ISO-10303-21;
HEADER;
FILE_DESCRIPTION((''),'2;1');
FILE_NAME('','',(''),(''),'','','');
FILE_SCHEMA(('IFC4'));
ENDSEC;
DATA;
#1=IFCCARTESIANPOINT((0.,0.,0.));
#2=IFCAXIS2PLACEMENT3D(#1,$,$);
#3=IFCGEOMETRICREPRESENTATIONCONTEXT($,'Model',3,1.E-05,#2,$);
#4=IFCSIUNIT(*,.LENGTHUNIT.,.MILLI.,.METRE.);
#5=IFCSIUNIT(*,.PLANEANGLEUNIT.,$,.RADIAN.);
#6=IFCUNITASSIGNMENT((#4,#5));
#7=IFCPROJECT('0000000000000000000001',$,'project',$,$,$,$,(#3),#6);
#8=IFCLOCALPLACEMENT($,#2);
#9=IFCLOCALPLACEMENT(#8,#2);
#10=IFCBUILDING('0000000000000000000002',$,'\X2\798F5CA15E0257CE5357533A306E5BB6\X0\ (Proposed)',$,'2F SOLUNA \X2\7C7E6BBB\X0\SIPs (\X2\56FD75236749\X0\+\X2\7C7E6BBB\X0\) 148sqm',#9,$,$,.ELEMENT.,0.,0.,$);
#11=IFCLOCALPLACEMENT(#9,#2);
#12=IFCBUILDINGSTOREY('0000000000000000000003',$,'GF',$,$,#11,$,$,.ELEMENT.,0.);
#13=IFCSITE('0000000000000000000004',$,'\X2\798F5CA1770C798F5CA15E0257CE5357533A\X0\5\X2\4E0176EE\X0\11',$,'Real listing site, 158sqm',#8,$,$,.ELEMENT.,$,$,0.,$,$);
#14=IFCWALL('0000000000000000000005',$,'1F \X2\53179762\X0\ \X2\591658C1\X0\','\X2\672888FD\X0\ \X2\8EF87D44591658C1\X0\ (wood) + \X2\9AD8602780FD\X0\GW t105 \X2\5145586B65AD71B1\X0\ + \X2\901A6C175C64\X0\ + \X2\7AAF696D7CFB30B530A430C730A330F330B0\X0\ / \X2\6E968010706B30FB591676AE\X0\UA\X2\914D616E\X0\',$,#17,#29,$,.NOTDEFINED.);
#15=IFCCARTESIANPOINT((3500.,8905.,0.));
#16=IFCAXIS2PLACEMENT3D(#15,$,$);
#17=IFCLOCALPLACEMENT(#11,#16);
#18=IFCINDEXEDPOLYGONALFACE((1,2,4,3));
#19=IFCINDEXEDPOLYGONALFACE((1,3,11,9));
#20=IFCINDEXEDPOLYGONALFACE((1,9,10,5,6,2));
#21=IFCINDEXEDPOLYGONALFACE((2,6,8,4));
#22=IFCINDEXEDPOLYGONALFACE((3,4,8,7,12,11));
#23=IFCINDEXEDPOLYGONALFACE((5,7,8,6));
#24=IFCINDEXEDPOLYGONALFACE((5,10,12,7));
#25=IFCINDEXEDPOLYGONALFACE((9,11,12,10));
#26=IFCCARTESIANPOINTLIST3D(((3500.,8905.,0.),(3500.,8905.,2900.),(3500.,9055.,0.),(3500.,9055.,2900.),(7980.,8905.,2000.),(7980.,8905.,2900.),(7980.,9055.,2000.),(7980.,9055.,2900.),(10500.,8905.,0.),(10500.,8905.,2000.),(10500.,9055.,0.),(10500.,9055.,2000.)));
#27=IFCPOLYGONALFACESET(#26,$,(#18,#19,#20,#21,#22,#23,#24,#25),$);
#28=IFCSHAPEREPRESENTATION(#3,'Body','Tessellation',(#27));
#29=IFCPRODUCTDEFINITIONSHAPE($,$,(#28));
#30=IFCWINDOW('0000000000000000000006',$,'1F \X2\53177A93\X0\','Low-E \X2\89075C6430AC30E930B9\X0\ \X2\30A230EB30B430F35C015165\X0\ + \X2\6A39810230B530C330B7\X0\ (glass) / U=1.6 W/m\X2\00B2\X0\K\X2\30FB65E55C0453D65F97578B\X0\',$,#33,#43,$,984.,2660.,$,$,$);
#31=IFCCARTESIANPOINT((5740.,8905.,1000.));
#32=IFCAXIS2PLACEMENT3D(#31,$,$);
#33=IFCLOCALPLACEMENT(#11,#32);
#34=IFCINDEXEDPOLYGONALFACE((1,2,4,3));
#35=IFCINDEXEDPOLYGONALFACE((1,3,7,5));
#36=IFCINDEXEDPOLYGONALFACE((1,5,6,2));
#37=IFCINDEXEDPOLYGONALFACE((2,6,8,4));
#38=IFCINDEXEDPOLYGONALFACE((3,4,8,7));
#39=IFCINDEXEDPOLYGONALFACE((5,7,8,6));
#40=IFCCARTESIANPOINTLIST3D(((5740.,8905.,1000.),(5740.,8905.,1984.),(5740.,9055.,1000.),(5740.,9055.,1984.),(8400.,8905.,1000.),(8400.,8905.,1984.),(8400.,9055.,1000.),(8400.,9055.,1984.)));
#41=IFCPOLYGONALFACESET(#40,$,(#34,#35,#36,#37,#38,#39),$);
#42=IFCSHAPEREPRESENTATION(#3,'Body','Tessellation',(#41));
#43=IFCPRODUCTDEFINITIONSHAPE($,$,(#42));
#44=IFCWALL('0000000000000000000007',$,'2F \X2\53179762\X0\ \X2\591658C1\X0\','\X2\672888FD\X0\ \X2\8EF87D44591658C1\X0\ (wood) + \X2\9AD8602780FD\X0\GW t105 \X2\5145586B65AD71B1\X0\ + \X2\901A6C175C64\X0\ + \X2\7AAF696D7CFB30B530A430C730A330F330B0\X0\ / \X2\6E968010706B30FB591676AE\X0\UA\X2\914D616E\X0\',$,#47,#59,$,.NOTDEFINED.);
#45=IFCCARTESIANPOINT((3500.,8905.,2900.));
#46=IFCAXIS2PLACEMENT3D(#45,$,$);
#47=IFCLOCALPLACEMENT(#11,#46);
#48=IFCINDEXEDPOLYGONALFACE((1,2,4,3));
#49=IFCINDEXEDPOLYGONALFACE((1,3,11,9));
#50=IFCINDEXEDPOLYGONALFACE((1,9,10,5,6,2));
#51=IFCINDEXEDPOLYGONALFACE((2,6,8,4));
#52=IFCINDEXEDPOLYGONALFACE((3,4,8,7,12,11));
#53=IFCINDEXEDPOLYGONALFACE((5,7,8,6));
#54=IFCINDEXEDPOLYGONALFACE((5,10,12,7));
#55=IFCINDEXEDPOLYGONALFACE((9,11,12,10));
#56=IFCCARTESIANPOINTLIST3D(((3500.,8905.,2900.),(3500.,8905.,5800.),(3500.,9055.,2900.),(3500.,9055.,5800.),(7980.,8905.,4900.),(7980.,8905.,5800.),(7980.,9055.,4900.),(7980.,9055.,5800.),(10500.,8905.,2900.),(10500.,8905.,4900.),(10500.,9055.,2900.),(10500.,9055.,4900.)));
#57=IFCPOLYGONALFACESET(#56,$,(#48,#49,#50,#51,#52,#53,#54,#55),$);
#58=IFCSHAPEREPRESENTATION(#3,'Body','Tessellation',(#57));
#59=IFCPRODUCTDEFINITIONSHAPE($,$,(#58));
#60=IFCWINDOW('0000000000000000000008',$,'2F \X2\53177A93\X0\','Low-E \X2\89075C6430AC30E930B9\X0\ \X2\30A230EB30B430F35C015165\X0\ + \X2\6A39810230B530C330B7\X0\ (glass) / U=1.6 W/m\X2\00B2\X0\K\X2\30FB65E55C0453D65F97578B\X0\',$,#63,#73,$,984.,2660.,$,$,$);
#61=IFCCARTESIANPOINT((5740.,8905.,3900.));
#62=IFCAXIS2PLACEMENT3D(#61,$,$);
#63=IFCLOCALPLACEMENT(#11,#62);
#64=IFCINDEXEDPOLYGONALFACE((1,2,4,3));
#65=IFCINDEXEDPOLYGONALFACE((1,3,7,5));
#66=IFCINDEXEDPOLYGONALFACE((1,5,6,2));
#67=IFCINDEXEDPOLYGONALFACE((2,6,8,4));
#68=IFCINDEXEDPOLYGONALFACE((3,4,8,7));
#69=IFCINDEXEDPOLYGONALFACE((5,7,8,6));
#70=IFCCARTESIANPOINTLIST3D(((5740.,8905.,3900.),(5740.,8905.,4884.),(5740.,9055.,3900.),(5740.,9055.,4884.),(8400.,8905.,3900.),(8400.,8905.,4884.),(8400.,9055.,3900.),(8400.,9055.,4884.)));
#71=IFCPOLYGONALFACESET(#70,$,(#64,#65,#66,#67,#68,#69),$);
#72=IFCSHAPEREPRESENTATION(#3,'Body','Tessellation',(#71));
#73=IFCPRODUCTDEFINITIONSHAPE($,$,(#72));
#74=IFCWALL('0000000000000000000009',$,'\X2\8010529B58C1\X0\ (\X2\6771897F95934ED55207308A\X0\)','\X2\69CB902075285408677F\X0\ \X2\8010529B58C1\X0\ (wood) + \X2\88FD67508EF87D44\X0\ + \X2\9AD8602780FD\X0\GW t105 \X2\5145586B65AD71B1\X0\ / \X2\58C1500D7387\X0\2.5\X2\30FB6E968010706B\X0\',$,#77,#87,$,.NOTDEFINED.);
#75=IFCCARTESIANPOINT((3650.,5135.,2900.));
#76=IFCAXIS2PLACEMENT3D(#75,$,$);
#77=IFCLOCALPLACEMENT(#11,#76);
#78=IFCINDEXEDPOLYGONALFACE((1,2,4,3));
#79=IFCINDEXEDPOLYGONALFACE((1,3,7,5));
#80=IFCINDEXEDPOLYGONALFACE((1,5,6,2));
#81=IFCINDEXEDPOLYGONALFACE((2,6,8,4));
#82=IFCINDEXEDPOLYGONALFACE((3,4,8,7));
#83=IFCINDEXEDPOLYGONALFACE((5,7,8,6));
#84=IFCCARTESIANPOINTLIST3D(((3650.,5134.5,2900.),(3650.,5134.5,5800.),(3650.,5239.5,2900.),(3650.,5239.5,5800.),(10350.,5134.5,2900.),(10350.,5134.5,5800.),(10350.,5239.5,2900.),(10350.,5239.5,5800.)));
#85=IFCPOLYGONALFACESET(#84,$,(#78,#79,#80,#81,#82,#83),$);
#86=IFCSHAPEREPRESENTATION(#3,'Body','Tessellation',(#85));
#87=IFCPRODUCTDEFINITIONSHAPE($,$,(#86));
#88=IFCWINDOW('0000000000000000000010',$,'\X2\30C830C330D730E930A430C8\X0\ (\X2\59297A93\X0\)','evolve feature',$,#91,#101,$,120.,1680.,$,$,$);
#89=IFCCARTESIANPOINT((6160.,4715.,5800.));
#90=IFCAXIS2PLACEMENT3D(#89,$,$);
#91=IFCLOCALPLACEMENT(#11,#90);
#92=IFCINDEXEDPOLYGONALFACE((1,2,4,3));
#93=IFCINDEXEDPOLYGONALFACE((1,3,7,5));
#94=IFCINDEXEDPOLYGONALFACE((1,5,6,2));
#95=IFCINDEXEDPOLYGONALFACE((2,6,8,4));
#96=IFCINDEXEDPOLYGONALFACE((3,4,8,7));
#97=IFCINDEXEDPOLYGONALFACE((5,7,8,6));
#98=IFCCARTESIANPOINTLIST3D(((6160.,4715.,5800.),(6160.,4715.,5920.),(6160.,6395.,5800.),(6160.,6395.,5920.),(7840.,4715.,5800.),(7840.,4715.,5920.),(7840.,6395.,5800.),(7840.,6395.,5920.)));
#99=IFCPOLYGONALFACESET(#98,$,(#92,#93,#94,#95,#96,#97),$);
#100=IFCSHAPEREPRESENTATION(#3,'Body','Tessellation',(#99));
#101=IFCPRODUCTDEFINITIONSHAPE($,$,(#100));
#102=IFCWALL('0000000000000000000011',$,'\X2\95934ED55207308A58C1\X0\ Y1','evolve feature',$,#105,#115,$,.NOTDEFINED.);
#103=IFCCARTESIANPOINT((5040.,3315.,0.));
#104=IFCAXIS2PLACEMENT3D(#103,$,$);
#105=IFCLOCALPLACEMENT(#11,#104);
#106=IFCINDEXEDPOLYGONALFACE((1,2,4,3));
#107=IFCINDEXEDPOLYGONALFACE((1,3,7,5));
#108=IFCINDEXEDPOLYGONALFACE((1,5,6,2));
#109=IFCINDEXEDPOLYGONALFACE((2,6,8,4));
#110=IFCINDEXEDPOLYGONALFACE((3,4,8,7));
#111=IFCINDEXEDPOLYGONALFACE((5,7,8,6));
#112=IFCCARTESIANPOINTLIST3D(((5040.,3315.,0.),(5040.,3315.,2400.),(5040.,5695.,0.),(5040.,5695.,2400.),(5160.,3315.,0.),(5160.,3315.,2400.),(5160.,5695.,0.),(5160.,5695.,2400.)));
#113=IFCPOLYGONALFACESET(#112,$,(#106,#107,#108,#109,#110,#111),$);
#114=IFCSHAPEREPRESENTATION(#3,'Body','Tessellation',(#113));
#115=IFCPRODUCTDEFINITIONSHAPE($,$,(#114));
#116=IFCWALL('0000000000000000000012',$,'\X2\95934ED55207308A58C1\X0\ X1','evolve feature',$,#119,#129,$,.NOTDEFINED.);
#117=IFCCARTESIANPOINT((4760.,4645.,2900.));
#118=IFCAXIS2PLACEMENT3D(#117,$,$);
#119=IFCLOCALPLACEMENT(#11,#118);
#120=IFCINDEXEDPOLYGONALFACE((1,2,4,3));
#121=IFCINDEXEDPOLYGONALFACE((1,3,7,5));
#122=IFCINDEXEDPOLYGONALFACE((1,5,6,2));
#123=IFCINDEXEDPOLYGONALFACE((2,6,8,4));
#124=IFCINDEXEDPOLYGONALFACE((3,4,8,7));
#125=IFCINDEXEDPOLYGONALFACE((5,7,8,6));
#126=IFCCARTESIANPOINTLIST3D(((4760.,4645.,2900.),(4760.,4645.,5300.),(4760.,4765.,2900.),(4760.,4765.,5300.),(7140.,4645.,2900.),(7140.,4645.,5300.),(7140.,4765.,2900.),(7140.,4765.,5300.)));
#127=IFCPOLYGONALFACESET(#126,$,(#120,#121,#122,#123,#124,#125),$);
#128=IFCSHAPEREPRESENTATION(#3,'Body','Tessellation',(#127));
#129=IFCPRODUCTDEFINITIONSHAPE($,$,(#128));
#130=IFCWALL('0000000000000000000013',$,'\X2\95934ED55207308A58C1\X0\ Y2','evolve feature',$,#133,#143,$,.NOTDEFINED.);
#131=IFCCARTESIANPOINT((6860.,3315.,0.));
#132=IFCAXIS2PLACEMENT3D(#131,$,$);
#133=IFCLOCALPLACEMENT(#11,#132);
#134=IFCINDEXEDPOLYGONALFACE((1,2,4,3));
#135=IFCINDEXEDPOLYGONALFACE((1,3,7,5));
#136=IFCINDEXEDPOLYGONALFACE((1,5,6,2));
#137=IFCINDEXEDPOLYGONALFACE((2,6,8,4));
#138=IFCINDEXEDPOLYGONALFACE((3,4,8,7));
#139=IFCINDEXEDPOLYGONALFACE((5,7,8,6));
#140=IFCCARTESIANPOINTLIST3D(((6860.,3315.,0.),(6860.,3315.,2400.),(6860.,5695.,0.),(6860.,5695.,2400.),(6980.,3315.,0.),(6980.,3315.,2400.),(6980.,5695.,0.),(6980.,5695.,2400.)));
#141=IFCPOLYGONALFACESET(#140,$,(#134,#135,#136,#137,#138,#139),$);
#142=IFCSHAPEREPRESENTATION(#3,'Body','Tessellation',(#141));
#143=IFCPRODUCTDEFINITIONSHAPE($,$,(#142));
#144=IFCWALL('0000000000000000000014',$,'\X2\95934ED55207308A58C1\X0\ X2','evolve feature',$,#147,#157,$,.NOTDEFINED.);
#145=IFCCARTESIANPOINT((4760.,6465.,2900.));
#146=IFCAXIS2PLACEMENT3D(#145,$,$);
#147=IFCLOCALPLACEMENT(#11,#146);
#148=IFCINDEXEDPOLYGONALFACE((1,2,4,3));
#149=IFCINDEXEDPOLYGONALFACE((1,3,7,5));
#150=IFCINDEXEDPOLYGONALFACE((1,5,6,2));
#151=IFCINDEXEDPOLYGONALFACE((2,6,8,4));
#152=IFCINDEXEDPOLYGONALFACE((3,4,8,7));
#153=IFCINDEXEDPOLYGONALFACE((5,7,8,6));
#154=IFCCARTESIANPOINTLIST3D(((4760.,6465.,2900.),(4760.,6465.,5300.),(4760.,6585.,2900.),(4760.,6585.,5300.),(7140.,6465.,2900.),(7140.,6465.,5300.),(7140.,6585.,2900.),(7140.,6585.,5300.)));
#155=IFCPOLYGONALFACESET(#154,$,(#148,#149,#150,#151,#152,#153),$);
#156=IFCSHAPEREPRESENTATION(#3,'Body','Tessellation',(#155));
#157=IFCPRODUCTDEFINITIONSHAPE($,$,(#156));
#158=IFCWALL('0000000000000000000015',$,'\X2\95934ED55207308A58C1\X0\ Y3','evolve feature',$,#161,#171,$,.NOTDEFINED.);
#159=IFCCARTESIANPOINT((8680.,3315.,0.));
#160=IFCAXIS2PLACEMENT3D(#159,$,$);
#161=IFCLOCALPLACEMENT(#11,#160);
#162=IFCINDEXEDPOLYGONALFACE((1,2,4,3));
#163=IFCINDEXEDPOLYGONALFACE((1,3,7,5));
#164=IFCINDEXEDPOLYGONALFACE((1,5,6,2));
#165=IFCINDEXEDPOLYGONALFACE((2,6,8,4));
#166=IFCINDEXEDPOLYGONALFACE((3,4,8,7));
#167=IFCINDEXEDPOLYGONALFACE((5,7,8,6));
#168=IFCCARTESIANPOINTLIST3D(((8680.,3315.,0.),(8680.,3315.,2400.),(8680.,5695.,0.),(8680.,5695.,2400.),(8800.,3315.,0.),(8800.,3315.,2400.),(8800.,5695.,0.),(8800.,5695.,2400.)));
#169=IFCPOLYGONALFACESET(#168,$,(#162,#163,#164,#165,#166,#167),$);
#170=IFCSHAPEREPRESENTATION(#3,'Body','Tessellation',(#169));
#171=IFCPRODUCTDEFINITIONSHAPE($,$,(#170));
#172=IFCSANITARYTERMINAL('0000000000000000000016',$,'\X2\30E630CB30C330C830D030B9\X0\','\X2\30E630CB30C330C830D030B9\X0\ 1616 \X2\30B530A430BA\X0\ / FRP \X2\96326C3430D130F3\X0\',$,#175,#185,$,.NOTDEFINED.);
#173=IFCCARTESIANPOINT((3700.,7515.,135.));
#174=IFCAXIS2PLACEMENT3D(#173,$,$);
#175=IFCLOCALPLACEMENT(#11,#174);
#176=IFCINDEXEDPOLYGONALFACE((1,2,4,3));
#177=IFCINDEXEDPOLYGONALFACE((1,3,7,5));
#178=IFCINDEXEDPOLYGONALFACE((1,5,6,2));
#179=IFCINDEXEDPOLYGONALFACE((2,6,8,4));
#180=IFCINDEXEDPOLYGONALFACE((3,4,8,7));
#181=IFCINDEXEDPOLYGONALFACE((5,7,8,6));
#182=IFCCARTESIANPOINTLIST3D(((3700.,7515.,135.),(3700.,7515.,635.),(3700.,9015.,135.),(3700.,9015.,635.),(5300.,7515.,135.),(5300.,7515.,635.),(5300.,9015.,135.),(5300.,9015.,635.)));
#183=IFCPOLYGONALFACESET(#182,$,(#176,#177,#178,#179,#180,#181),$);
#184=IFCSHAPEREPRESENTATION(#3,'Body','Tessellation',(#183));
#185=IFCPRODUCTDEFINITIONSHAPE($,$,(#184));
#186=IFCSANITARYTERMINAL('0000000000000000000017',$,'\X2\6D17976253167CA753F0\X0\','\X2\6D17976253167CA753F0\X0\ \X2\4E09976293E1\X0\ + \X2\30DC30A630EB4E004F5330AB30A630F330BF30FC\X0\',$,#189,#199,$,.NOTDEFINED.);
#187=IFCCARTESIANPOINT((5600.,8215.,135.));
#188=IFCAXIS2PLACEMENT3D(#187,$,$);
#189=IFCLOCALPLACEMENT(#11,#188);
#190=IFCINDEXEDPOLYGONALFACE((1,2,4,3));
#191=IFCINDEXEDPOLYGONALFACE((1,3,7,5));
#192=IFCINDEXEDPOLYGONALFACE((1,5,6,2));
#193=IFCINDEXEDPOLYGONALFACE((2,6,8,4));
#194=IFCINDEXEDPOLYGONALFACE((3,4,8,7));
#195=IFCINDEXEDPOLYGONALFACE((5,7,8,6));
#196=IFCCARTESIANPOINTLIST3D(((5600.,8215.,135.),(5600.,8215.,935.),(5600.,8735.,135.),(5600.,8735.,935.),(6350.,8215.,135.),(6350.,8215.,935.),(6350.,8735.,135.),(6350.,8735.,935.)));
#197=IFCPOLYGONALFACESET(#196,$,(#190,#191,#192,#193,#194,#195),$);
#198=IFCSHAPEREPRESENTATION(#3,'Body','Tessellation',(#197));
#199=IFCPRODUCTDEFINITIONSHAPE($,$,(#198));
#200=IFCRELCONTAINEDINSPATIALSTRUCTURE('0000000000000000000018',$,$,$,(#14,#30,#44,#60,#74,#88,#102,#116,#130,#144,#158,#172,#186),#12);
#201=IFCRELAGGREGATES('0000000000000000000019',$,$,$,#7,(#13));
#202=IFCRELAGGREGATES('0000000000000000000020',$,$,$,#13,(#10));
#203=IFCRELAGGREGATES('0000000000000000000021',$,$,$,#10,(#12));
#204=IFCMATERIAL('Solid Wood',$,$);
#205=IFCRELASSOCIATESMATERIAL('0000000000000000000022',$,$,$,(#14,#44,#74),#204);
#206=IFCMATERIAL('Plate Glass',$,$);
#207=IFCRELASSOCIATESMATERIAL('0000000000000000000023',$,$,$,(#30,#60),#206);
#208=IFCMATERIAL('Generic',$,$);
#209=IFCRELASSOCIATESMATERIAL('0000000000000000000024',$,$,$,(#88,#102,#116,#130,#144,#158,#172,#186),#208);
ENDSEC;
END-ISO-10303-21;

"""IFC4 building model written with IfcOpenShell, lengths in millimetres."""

from ifc_helpers import new_model, si_unit, frame, frame_2d, origin, place, context, project, spatial, rectangle, extrude, material, element, fill, save


model = new_model("IFC4")

# Units and contexts
model_context = context("Model", 3, precision=1e-05, world=origin())
ifc_project = project(units=[si_unit("LENGTHUNIT", "METRE", prefix="MILLI"), si_unit("PLANEANGLEUNIT", "RADIAN")], contexts=[model_context])

# Site, building, storey
site_placement = place(None, origin())
site = spatial("IfcSite", under=ifc_project, at=site_placement, Name="福岡県福岡市城南区5丁目11", ObjectType="Real listing site, 158sqm", CompositionType="ELEMENT", RefElevation=0.0)
building_placement = place(site_placement, origin())
building = spatial("IfcBuilding", under=site, at=building_placement, Name="福岡市城南区の家 (Proposed)", ObjectType="2F SOLUNA 籾殻SIPs (国産杉+籾殻) 148sqm", CompositionType="ELEMENT", ElevationOfRefHeight=0.0, ElevationOfTerrain=0.0)
storey_placement = place(building_placement, origin())
storey = spatial("IfcBuildingStorey", under=building, at=storey_placement, Name="GF", CompositionType="ELEMENT", Elevation=0.0)

# Wall, opening, window
ifc_material_1 = material(Name="Solid Wood")
wall_1_placement = place(storey_placement, frame((3500.0, 8905.0, 0.0)))
wall_1 = element("IfcWall", 1, at=wall_1_placement, inside=storey, material=ifc_material_1, Name="1F 北面 外壁", Description="木製 軸組外壁 (wood) + 高性能GW t105 充填断熱 + 通気層 + 窯業系サイディング / 準耐火・外皮UA配慮", PredefinedType="NOTDEFINED", context=model_context, shape_type="SweptSolid", body=[
    extrude(rectangle(XDim=7000.0, YDim=150.0, at=frame_2d((3500.0, 75.0))), frame((3500.0, 8905.0, 0.0)), (0.0, 0.0, 1.0), 2900.0),
])
opening_1_placement = place(storey_placement, frame((5740.0, 8905.0, 1000.0)))
opening_1 = element("IfcOpeningElement", 2, at=opening_1_placement, cuts=wall_1, PredefinedType="NOTDEFINED", context=model_context, shape_type="SweptSolid", body=[
    extrude(rectangle(XDim=2660.0, YDim=150.0, at=frame_2d((1330.0, 75.0))), frame((5740.0, 8905.0, 1000.0)), (0.0, 0.0, 1.0), 984.0),
])
ifc_material_2 = material(Name="Plate Glass")
window_1_placement = place(storey_placement, frame((5740.0, 8905.0, 1000.0)))
window_1 = element("IfcWindow", 3, at=window_1_placement, inside=storey, material=ifc_material_2, Name="1F 北窓", Description="Low-E 複層ガラス アルゴン封入 + 樹脂サッシ (glass) / U=1.6 W/m²K・日射取得型", OverallHeight=984.0, OverallWidth=2660.0, context=model_context, shape_type="SweptSolid", body=[
    extrude(rectangle(XDim=2660.0, YDim=150.0, at=frame_2d((1330.0, 75.0))), frame((5740.0, 8905.0, 1000.0)), (0.0, 0.0, 1.0), 984.0),
])
fill(opening_1, window_1)

# Wall, opening, window
wall_2_placement = place(storey_placement, frame((3500.0, 8905.0, 2900.0)))
wall_2 = element("IfcWall", 4, at=wall_2_placement, inside=storey, material=ifc_material_1, Name="2F 北面 外壁", Description="木製 軸組外壁 (wood) + 高性能GW t105 充填断熱 + 通気層 + 窯業系サイディング / 準耐火・外皮UA配慮", PredefinedType="NOTDEFINED", context=model_context, shape_type="SweptSolid", body=[
    extrude(rectangle(XDim=7000.0, YDim=150.0, at=frame_2d((3500.0, 75.0))), frame((3500.0, 8905.0, 2900.0)), (0.0, 0.0, 1.0), 2900.0),
])
opening_2_placement = place(storey_placement, frame((5740.0, 8905.0, 3900.0)))
opening_2 = element("IfcOpeningElement", 5, at=opening_2_placement, cuts=wall_2, PredefinedType="NOTDEFINED", context=model_context, shape_type="SweptSolid", body=[
    extrude(rectangle(XDim=2660.0, YDim=150.0, at=frame_2d((1330.0, 75.0))), frame((5740.0, 8905.0, 3900.0)), (0.0, 0.0, 1.0), 984.0),
])
window_2_placement = place(storey_placement, frame((5740.0, 8905.0, 3900.0)))
window_2 = element("IfcWindow", 6, at=window_2_placement, inside=storey, material=ifc_material_2, Name="2F 北窓", Description="Low-E 複層ガラス アルゴン封入 + 樹脂サッシ (glass) / U=1.6 W/m²K・日射取得型", OverallHeight=984.0, OverallWidth=2660.0, context=model_context, shape_type="SweptSolid", body=[
    extrude(rectangle(XDim=2660.0, YDim=150.0, at=frame_2d((1330.0, 75.0))), frame((5740.0, 8905.0, 3900.0)), (0.0, 0.0, 1.0), 984.0),
])
fill(opening_2, window_2)

# Wall
wall_3_placement = place(storey_placement, frame((3650.0, 5135.0, 2900.0)))
element("IfcWall", 7, at=wall_3_placement, inside=storey, material=ifc_material_1, Name="耐力壁 (東西間仕切り)", Description="構造用合板 耐力壁 (wood) + 製材軸組 + 高性能GW t105 充填断熱 / 壁倍率2.5・準耐火", PredefinedType="NOTDEFINED", context=model_context, shape_type="SweptSolid", body=[
    extrude(rectangle(XDim=6700.0, YDim=105.0, at=frame_2d((3350.0, 52.0))), frame((3650.0, 5135.0, 2900.0)), (0.0, 0.0, 1.0), 2900.0),
])

# Window
ifc_material_3 = material(Name="Generic")
window_3_placement = place(storey_placement, frame((6160.0, 4715.0, 5800.0)))
element("IfcWindow", 8, at=window_3_placement, inside=storey, material=ifc_material_3, Name="トップライト (天窓)", Description="evolve feature", OverallHeight=120.0, OverallWidth=1680.0, context=model_context, shape_type="SweptSolid", body=[
    extrude(rectangle(XDim=1680.0, YDim=1680.0, at=frame_2d((840.0, 840.0))), frame((6160.0, 4715.0, 5800.0)), (0.0, 0.0, 1.0), 120.0),
])

# Walls
wall_4_placement = place(storey_placement, frame((5040.0, 3315.0, 0.0)))
element("IfcWall", 9, at=wall_4_placement, inside=storey, material=ifc_material_3, Name="間仕切り壁 Y1", Description="evolve feature", PredefinedType="NOTDEFINED", context=model_context, shape_type="SweptSolid", body=[
    extrude(rectangle(XDim=120.0, YDim=2380.0, at=frame_2d((60.0, 1190.0))), frame((5040.0, 3315.0, 0.0)), (0.0, 0.0, 1.0), 2400.0),
])
wall_5_placement = place(storey_placement, frame((4760.0, 4645.0, 2900.0)))
element("IfcWall", 10, at=wall_5_placement, inside=storey, material=ifc_material_3, Name="間仕切り壁 X1", Description="evolve feature", PredefinedType="NOTDEFINED", context=model_context, shape_type="SweptSolid", body=[
    extrude(rectangle(XDim=2380.0, YDim=120.0, at=frame_2d((1190.0, 60.0))), frame((4760.0, 4645.0, 2900.0)), (0.0, 0.0, 1.0), 2400.0),
])
wall_6_placement = place(storey_placement, frame((6860.0, 3315.0, 0.0)))
element("IfcWall", 11, at=wall_6_placement, inside=storey, material=ifc_material_3, Name="間仕切り壁 Y2", Description="evolve feature", PredefinedType="NOTDEFINED", context=model_context, shape_type="SweptSolid", body=[
    extrude(rectangle(XDim=120.0, YDim=2380.0, at=frame_2d((60.0, 1190.0))), frame((6860.0, 3315.0, 0.0)), (0.0, 0.0, 1.0), 2400.0),
])
wall_7_placement = place(storey_placement, frame((4760.0, 6465.0, 2900.0)))
element("IfcWall", 12, at=wall_7_placement, inside=storey, material=ifc_material_3, Name="間仕切り壁 X2", Description="evolve feature", PredefinedType="NOTDEFINED", context=model_context, shape_type="SweptSolid", body=[
    extrude(rectangle(XDim=2380.0, YDim=120.0, at=frame_2d((1190.0, 60.0))), frame((4760.0, 6465.0, 2900.0)), (0.0, 0.0, 1.0), 2400.0),
])
wall_8_placement = place(storey_placement, frame((8680.0, 3315.0, 0.0)))
element("IfcWall", 13, at=wall_8_placement, inside=storey, material=ifc_material_3, Name="間仕切り壁 Y3", Description="evolve feature", PredefinedType="NOTDEFINED", context=model_context, shape_type="SweptSolid", body=[
    extrude(rectangle(XDim=120.0, YDim=2380.0, at=frame_2d((60.0, 1190.0))), frame((8680.0, 3315.0, 0.0)), (0.0, 0.0, 1.0), 2400.0),
])

# Sanitary terminals
sanitary_terminal_1_placement = place(storey_placement, frame((3700.0, 7515.0, 135.0)))
element("IfcSanitaryTerminal", 14, at=sanitary_terminal_1_placement, inside=storey, material=ifc_material_3, Name="ユニットバス", Description="ユニットバス 1616 サイズ / FRP 防水パン", PredefinedType="NOTDEFINED", context=model_context, shape_type="SweptSolid", body=[
    extrude(rectangle(XDim=1600.0, YDim=1500.0, at=frame_2d((800.0, 750.0))), frame((3700.0, 7515.0, 135.0)), (0.0, 0.0, 1.0), 500.0),
])
sanitary_terminal_2_placement = place(storey_placement, frame((5600.0, 8215.0, 135.0)))
element("IfcSanitaryTerminal", 15, at=sanitary_terminal_2_placement, inside=storey, material=ifc_material_3, Name="洗面化粧台", Description="洗面化粧台 三面鏡 + ボウル一体カウンター", PredefinedType="NOTDEFINED", context=model_context, shape_type="SweptSolid", body=[
    extrude(rectangle(XDim=750.0, YDim=520.0, at=frame_2d((375.0, 260.0))), frame((5600.0, 8215.0, 135.0)), (0.0, 0.0, 1.0), 800.0),
])

save(model, "model.ifc")
